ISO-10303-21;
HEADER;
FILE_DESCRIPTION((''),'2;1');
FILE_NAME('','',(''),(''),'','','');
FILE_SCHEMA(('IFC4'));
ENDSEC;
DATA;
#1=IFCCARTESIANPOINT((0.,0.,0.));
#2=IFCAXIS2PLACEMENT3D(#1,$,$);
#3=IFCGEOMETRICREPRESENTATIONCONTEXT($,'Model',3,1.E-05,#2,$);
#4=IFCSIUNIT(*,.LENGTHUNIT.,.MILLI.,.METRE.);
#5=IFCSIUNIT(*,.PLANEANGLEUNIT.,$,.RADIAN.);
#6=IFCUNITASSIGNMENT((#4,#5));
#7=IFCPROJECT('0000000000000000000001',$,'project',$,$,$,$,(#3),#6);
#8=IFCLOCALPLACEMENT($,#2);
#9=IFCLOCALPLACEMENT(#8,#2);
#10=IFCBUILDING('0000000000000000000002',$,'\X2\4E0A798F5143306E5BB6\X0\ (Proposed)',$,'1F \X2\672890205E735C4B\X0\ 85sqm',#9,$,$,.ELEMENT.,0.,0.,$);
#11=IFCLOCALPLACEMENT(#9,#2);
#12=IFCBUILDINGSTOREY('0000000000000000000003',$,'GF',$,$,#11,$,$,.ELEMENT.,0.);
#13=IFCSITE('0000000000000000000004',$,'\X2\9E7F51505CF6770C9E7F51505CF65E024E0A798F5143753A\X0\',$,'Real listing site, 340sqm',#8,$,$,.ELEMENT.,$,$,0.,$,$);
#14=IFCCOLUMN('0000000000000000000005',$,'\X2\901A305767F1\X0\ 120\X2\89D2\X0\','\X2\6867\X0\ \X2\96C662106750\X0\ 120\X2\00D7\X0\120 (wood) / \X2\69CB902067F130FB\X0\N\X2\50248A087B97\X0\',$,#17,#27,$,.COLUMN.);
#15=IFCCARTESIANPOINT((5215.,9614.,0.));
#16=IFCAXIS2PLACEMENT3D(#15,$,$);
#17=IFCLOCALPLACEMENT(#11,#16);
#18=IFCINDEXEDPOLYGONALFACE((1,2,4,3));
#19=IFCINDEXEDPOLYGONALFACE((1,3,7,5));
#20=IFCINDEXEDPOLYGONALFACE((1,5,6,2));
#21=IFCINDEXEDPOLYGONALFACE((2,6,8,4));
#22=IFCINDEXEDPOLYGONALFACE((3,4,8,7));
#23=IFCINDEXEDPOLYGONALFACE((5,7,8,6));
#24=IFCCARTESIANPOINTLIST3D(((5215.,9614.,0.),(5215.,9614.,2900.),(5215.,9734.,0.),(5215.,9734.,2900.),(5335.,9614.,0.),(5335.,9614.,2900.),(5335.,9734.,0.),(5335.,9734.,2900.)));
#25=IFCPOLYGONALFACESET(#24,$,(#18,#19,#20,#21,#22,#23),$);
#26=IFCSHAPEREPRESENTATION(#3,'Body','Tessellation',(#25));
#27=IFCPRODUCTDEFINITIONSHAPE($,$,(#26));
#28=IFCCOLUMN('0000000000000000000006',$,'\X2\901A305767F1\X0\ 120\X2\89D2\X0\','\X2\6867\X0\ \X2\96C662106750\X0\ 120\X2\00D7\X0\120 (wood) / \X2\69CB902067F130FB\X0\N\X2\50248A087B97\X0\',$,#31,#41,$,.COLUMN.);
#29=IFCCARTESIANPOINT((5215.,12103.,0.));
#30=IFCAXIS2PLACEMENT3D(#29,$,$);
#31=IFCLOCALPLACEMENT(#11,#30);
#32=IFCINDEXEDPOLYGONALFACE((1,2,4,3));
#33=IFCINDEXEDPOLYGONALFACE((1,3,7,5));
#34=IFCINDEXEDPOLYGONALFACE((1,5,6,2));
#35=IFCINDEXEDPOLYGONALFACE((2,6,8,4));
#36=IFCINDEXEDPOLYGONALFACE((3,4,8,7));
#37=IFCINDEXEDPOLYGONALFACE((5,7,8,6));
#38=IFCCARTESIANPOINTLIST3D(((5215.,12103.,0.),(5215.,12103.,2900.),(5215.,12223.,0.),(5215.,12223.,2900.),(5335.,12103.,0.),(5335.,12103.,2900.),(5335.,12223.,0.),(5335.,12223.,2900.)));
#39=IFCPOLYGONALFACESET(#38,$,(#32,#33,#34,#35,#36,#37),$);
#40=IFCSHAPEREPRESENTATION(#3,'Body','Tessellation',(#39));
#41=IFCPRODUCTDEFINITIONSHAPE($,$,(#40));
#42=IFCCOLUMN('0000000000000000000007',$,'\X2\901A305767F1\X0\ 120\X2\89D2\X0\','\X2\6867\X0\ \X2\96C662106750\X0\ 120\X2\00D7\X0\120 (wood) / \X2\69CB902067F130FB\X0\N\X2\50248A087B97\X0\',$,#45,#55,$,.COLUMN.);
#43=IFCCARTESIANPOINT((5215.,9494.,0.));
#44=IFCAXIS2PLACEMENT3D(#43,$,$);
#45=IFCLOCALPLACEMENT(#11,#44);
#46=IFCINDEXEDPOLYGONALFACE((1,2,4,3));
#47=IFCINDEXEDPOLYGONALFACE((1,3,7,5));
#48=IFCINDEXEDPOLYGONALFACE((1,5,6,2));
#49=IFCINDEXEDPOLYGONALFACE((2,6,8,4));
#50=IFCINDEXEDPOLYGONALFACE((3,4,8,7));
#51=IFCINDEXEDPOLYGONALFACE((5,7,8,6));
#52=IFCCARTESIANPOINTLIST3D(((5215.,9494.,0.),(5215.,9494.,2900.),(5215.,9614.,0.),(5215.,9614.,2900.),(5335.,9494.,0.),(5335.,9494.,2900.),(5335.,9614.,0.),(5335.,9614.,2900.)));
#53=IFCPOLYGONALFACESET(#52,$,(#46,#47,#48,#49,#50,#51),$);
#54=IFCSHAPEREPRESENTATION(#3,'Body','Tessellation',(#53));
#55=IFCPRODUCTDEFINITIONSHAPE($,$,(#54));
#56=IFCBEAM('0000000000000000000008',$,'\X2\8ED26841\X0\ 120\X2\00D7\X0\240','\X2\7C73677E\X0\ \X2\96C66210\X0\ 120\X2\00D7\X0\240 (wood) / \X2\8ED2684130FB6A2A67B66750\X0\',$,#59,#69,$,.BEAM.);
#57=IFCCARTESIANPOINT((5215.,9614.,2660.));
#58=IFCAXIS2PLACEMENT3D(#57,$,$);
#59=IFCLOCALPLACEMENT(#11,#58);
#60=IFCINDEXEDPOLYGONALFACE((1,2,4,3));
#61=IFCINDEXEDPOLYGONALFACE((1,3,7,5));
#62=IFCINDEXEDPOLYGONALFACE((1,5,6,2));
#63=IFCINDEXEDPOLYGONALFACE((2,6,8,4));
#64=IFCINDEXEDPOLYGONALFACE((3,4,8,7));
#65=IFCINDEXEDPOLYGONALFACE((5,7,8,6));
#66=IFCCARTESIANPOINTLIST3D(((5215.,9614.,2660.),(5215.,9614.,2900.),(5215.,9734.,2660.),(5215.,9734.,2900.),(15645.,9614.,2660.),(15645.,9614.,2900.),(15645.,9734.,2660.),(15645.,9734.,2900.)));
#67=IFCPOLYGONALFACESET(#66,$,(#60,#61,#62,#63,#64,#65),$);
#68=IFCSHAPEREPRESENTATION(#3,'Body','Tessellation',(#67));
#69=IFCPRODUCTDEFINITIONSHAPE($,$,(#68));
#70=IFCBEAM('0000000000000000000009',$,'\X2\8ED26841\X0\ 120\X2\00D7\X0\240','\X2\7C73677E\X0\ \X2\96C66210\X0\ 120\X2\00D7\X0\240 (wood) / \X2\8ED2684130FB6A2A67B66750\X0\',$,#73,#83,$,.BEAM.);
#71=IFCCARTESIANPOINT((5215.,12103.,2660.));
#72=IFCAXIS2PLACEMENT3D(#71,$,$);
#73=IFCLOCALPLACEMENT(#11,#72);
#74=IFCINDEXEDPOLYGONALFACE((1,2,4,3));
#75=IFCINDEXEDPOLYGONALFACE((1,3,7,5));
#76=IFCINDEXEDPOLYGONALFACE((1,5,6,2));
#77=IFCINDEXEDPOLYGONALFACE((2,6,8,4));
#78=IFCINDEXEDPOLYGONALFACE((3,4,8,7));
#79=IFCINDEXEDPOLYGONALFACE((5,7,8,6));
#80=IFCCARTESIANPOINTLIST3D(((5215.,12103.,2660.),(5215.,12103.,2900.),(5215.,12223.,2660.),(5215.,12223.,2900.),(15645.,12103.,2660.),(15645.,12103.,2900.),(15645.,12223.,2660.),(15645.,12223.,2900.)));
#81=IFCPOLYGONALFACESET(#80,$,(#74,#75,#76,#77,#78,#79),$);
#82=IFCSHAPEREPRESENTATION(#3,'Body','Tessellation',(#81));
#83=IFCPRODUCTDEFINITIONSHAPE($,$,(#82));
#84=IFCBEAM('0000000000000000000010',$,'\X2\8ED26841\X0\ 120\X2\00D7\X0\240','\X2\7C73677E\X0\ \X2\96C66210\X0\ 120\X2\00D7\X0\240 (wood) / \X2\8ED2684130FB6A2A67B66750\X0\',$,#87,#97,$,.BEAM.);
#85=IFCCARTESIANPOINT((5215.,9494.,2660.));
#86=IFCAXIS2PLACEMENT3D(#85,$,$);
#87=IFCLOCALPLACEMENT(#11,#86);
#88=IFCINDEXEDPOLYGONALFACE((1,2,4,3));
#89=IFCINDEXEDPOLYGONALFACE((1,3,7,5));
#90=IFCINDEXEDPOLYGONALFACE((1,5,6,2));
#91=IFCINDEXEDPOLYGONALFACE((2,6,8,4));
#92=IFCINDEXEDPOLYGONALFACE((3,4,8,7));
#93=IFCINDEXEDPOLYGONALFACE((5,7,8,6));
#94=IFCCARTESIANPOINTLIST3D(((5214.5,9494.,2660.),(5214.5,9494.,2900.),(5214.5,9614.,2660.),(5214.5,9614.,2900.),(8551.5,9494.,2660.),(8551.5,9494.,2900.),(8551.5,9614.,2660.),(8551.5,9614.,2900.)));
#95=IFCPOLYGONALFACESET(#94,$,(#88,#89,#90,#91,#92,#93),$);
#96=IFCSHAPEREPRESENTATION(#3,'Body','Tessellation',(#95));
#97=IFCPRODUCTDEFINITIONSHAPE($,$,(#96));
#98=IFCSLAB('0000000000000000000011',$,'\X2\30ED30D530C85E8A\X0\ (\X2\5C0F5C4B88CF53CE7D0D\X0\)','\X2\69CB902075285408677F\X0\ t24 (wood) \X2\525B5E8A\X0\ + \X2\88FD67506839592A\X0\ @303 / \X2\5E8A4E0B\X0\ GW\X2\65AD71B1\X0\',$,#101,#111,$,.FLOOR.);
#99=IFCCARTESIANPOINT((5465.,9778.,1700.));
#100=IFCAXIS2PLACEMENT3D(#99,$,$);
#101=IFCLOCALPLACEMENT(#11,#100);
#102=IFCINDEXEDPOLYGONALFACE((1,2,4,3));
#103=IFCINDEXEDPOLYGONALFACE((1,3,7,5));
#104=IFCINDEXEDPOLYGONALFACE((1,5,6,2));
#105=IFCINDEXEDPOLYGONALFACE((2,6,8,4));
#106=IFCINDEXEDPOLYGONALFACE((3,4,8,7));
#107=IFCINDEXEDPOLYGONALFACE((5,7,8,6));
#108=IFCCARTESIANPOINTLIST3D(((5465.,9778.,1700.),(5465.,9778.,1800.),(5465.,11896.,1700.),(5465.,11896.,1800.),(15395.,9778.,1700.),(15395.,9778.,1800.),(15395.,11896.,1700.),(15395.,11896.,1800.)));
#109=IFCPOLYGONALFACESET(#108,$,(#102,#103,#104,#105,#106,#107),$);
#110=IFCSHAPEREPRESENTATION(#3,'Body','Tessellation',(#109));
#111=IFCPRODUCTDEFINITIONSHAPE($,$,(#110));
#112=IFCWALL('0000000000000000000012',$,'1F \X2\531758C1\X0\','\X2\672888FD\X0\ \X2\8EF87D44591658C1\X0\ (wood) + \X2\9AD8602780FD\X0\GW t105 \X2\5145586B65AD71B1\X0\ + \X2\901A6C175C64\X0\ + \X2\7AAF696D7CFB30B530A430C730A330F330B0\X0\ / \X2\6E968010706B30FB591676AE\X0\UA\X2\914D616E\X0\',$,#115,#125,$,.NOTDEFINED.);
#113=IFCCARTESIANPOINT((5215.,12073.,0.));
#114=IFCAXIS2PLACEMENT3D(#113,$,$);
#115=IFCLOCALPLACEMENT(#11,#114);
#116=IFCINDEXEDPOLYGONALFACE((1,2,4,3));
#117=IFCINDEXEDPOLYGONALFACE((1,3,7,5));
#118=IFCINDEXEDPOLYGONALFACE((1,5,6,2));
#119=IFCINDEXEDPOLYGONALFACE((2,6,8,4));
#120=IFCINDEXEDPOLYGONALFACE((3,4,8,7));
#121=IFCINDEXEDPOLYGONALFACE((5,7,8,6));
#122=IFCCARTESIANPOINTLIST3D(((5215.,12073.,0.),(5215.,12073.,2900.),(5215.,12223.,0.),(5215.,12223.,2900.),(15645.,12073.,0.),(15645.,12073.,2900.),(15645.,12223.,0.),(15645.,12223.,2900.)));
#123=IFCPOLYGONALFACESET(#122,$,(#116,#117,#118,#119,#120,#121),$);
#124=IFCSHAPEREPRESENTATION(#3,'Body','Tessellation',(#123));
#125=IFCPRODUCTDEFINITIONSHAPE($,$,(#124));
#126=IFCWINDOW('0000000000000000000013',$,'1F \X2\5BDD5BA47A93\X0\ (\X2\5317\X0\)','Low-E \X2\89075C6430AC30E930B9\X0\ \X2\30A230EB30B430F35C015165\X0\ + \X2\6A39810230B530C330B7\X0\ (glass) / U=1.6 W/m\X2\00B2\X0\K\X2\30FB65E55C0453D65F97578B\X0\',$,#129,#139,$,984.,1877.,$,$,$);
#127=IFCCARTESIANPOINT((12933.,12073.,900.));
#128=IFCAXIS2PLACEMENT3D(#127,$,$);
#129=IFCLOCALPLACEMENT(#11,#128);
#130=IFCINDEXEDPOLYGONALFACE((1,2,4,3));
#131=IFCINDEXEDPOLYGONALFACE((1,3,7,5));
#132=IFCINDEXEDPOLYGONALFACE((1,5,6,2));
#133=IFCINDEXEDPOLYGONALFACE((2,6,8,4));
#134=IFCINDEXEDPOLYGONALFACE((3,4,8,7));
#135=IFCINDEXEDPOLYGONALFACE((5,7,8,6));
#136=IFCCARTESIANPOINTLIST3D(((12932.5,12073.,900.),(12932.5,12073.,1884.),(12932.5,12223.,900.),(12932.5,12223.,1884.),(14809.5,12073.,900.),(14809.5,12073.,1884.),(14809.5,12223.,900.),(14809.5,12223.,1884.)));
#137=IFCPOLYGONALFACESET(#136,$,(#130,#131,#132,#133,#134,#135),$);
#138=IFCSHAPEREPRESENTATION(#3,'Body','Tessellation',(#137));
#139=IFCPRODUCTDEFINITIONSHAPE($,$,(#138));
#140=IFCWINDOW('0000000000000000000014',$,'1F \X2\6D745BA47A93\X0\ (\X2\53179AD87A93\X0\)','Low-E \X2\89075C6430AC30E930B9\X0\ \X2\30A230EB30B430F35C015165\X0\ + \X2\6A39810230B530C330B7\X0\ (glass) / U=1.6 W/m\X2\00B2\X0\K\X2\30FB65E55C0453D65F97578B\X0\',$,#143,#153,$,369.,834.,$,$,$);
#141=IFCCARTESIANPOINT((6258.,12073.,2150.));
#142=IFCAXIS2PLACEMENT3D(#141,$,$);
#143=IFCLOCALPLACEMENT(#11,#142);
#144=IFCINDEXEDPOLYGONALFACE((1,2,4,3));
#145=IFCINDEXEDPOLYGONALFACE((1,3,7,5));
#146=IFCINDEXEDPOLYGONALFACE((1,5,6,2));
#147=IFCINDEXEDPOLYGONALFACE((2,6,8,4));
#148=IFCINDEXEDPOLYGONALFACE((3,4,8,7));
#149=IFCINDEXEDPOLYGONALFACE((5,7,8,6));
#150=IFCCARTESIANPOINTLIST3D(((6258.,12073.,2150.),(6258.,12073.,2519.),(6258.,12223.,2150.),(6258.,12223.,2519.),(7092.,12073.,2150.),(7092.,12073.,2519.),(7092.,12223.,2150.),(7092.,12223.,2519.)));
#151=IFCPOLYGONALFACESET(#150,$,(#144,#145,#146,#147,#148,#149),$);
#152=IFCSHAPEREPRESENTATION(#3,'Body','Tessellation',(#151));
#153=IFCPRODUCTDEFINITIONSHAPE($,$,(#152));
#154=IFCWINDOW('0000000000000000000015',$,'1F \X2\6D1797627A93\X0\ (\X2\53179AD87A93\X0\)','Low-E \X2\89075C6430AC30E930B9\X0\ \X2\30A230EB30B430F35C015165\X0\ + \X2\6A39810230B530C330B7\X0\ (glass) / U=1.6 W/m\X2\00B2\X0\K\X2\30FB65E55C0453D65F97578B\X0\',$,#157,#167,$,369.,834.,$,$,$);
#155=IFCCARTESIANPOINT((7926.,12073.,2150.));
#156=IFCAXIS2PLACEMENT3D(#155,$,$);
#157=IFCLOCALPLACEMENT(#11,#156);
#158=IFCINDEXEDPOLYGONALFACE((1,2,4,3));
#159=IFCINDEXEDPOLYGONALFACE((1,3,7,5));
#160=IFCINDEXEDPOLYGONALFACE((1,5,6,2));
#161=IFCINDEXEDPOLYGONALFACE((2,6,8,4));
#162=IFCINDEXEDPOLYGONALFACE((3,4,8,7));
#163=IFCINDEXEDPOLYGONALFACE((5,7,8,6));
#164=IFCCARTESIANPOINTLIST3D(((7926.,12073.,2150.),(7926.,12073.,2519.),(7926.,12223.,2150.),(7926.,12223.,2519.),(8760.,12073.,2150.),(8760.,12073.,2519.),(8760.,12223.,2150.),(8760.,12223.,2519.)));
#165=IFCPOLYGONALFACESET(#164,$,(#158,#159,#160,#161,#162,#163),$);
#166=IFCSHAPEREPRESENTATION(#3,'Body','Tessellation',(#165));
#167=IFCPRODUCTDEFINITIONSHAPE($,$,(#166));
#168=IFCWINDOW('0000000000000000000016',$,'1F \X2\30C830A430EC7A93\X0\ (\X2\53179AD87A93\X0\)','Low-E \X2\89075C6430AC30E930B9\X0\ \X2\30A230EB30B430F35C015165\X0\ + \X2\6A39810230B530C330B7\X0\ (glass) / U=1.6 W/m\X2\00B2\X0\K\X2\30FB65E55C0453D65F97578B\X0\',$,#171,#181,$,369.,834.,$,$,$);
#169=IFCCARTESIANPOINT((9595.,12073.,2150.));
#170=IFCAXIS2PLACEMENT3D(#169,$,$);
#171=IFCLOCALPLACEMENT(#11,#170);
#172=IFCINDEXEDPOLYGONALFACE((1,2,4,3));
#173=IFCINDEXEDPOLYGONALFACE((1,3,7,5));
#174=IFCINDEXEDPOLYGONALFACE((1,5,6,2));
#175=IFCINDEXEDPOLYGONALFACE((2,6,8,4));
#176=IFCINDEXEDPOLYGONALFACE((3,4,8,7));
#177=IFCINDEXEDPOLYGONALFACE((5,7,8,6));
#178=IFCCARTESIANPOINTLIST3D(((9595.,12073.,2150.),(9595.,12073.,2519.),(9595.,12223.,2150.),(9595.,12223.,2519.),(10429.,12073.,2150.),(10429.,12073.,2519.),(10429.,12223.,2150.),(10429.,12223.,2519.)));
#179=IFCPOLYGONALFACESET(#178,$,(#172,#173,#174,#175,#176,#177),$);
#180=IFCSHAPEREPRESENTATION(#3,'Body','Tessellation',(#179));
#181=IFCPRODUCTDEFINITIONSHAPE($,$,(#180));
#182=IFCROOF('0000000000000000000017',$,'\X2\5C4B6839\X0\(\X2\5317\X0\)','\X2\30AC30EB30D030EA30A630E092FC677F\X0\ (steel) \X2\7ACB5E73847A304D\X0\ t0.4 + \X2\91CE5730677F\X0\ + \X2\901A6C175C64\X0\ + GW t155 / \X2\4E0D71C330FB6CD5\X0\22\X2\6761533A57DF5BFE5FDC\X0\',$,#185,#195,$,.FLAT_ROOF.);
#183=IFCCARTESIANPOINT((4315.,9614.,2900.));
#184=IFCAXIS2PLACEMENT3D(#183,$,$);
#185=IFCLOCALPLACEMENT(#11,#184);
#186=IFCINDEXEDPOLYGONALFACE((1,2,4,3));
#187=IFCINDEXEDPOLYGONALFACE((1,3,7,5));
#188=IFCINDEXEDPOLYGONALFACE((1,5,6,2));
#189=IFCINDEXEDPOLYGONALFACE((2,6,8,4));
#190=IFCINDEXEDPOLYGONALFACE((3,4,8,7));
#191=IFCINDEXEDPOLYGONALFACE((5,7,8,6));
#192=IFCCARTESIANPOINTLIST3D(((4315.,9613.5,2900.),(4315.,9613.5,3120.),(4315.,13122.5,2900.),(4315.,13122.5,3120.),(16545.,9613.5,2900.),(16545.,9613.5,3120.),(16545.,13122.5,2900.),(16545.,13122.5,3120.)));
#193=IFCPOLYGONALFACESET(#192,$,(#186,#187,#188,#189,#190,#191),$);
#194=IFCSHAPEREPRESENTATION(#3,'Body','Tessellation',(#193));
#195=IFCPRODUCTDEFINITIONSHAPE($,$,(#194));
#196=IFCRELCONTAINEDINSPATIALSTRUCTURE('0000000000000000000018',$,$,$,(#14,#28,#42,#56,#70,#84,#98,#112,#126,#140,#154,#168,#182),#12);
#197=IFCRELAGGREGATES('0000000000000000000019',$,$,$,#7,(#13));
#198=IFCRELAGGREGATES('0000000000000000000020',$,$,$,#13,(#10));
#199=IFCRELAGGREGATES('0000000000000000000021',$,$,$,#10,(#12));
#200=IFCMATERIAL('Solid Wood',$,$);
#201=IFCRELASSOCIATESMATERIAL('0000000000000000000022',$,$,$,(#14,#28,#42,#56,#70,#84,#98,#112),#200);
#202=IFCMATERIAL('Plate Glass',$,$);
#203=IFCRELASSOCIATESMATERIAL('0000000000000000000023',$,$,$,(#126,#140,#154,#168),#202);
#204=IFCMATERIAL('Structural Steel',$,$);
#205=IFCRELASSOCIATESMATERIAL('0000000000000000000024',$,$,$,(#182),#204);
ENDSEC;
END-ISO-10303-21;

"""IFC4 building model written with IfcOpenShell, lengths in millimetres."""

from ifc_helpers import new_model, si_unit, frame, frame_2d, origin, place, context, project, spatial, rectangle, extrude, material, element, fill, save


model = new_model("IFC4")

# Units and contexts
model_context = context("Model", 3, precision=1e-05, world=origin())
ifc_project = project(units=[si_unit("LENGTHUNIT", "METRE", prefix="MILLI"), si_unit("PLANEANGLEUNIT", "RADIAN")], contexts=[model_context])

# Site, building, storey
site_placement = place(None, origin())
site = spatial("IfcSite", under=ifc_project, at=site_placement, Name="鹿児島県鹿児島市上福元町", ObjectType="Real listing site, 340sqm", CompositionType="ELEMENT", RefElevation=0.0)
building_placement = place(site_placement, origin())
building = spatial("IfcBuilding", under=site, at=building_placement, Name="上福元の家 (Proposed)", ObjectType="1F 木造平屋 85sqm", CompositionType="ELEMENT", ElevationOfRefHeight=0.0, ElevationOfTerrain=0.0)
storey_placement = place(building_placement, origin())
storey = spatial("IfcBuildingStorey", under=building, at=storey_placement, Name="GF", CompositionType="ELEMENT", Elevation=0.0)

# Columns
ifc_material_1 = material(Name="Solid Wood")
column_1_placement = place(storey_placement, frame((5215.0, 9614.0, 0.0)))
element("IfcColumn", 1, at=column_1_placement, inside=storey, material=ifc_material_1, Name="通し柱 120角", Description="桧 集成材 120×120 (wood) / 構造柱・N値計算", PredefinedType="COLUMN", context=model_context, shape_type="SweptSolid", body=[
    extrude(rectangle(XDim=120.0, YDim=120.0, at=frame_2d((60.0, 60.0))), frame((5215.0, 9614.0, 0.0)), (0.0, 0.0, 1.0), 2900.0),
])
column_2_placement = place(storey_placement, frame((5215.0, 12103.0, 0.0)))
element("IfcColumn", 2, at=column_2_placement, inside=storey, material=ifc_material_1, Name="通し柱 120角", Description="桧 集成材 120×120 (wood) / 構造柱・N値計算", PredefinedType="COLUMN", context=model_context, shape_type="SweptSolid", body=[
    extrude(rectangle(XDim=120.0, YDim=120.0, at=frame_2d((60.0, 60.0))), frame((5215.0, 12103.0, 0.0)), (0.0, 0.0, 1.0), 2900.0),
])
column_3_placement = place(storey_placement, frame((5215.0, 9494.0, 0.0)))
element("IfcColumn", 3, at=column_3_placement, inside=storey, material=ifc_material_1, Name="通し柱 120角", Description="桧 集成材 120×120 (wood) / 構造柱・N値計算", PredefinedType="COLUMN", context=model_context, shape_type="SweptSolid", body=[
    extrude(rectangle(XDim=120.0, YDim=120.0, at=frame_2d((60.0, 60.0))), frame((5215.0, 9494.0, 0.0)), (0.0, 0.0, 1.0), 2900.0),
])

# Beams
beam_1_placement = place(storey_placement, frame((5215.0, 9614.0, 2660.0)))
element("IfcBeam", 4, at=beam_1_placement, inside=storey, material=ifc_material_1, Name="軒桁 120×240", Description="米松 集成 120×240 (wood) / 軒桁・横架材", PredefinedType="BEAM", context=model_context, shape_type="SweptSolid", body=[
    extrude(rectangle(XDim=10430.0, YDim=120.0, at=frame_2d((5215.0, 60.0))), frame((5215.0, 9614.0, 2660.0)), (0.0, 0.0, 1.0), 240.0),
])
beam_2_placement = place(storey_placement, frame((5215.0, 12103.0, 2660.0)))
element("IfcBeam", 5, at=beam_2_placement, inside=storey, material=ifc_material_1, Name="軒桁 120×240", Description="米松 集成 120×240 (wood) / 軒桁・横架材", PredefinedType="BEAM", context=model_context, shape_type="SweptSolid", body=[
    extrude(rectangle(XDim=10430.0, YDim=120.0, at=frame_2d((5215.0, 60.0))), frame((5215.0, 12103.0, 2660.0)), (0.0, 0.0, 1.0), 240.0),
])
beam_3_placement = place(storey_placement, frame((5215.0, 9494.0, 2660.0)))
element("IfcBeam", 6, at=beam_3_placement, inside=storey, material=ifc_material_1, Name="軒桁 120×240", Description="米松 集成 120×240 (wood) / 軒桁・横架材", PredefinedType="BEAM", context=model_context, shape_type="SweptSolid", body=[
    extrude(rectangle(XDim=3337.0, YDim=120.0, at=frame_2d((1668.0, 60.0))), frame((5215.0, 9494.0, 2660.0)), (0.0, 0.0, 1.0), 240.0),
])

# Slab
slab_1_placement = place(storey_placement, frame((5465.0, 9778.0, 1700.0)))
element("IfcSlab", 7, at=slab_1_placement, inside=storey, material=ifc_material_1, Name="ロフト床 (小屋裏収納)", Description="構造用合板 t24 (wood) 剛床 + 製材根太 @303 / 床下 GW断熱", PredefinedType="FLOOR", context=model_context, shape_type="SweptSolid", body=[
    extrude(rectangle(XDim=9930.0, YDim=2118.0, at=frame_2d((4965.0, 1059.0))), frame((5465.0, 9778.0, 1700.0)), (0.0, 0.0, 1.0), 100.0),
])

# Wall, openings, windows
wall_1_placement = place(storey_placement, frame((5215.0, 12073.0, 0.0)))
wall_1 = element("IfcWall", 8, at=wall_1_placement, inside=storey, material=ifc_material_1, Name="1F 北壁", Description="木製 軸組外壁 (wood) + 高性能GW t105 充填断熱 + 通気層 + 窯業系サイディング / 準耐火・外皮UA配慮", PredefinedType="NOTDEFINED", context=model_context, shape_type="SweptSolid", body=[
    extrude(rectangle(XDim=10430.0, YDim=150.0, at=frame_2d((5215.0, 75.0))), frame((5215.0, 12073.0, 0.0)), (0.0, 0.0, 1.0), 2900.0),
])
opening_1_placement = place(storey_placement, frame((12933.0, 12073.0, 900.0)))
opening_1 = element("IfcOpeningElement", 9, at=opening_1_placement, cuts=wall_1, PredefinedType="NOTDEFINED", context=model_context, shape_type="SweptSolid", body=[
    extrude(rectangle(XDim=1877.0, YDim=150.0, at=frame_2d((938.0, 75.0))), frame((12933.0, 12073.0, 900.0)), (0.0, 0.0, 1.0), 984.0),
])
opening_2_placement = place(storey_placement, frame((6258.0, 12073.0, 2150.0)))
opening_2 = element("IfcOpeningElement", 10, at=opening_2_placement, cuts=wall_1, PredefinedType="NOTDEFINED", context=model_context, shape_type="SweptSolid", body=[
    extrude(rectangle(XDim=834.0, YDim=150.0, at=frame_2d((417.0, 75.0))), frame((6258.0, 12073.0, 2150.0)), (0.0, 0.0, 1.0), 369.0),
])
opening_3_placement = place(storey_placement, frame((7926.0, 12073.0, 2150.0)))
opening_3 = element("IfcOpeningElement", 11, at=opening_3_placement, cuts=wall_1, PredefinedType="NOTDEFINED", context=model_context, shape_type="SweptSolid", body=[
    extrude(rectangle(XDim=834.0, YDim=150.0, at=frame_2d((417.0, 75.0))), frame((7926.0, 12073.0, 2150.0)), (0.0, 0.0, 1.0), 369.0),
])
opening_4_placement = place(storey_placement, frame((9595.0, 12073.0, 2150.0)))
opening_4 = element("IfcOpeningElement", 12, at=opening_4_placement, cuts=wall_1, PredefinedType="NOTDEFINED", context=model_context, shape_type="SweptSolid", body=[
    extrude(rectangle(XDim=834.0, YDim=150.0, at=frame_2d((417.0, 75.0))), frame((9595.0, 12073.0, 2150.0)), (0.0, 0.0, 1.0), 369.0),
])
ifc_material_2 = material(Name="Plate Glass")
window_1_placement = place(storey_placement, frame((12933.0, 12073.0, 900.0)))
window_1 = element("IfcWindow", 13, at=window_1_placement, inside=storey, material=ifc_material_2, Name="1F 寝室窓 (北)", Description="Low-E 複層ガラス アルゴン封入 + 樹脂サッシ (glass) / U=1.6 W/m²K・日射取得型", OverallHeight=984.0, OverallWidth=1877.0, context=model_context, shape_type="SweptSolid", body=[
    extrude(rectangle(XDim=1877.0, YDim=150.0, at=frame_2d((938.0, 75.0))), frame((12933.0, 12073.0, 900.0)), (0.0, 0.0, 1.0), 984.0),
])
fill(opening_1, window_1)
window_2_placement = place(storey_placement, frame((6258.0, 12073.0, 2150.0)))
window_2 = element("IfcWindow", 14, at=window_2_placement, inside=storey, material=ifc_material_2, Name="1F 浴室窓 (北高窓)", Description="Low-E 複層ガラス アルゴン封入 + 樹脂サッシ (glass) / U=1.6 W/m²K・日射取得型", OverallHeight=369.0, OverallWidth=834.0, context=model_context, shape_type="SweptSolid", body=[
    extrude(rectangle(XDim=834.0, YDim=150.0, at=frame_2d((417.0, 75.0))), frame((6258.0, 12073.0, 2150.0)), (0.0, 0.0, 1.0), 369.0),
])
fill(opening_2, window_2)
window_3_placement = place(storey_placement, frame((7926.0, 12073.0, 2150.0)))
window_3 = element("IfcWindow", 15, at=window_3_placement, inside=storey, material=ifc_material_2, Name="1F 洗面窓 (北高窓)", Description="Low-E 複層ガラス アルゴン封入 + 樹脂サッシ (glass) / U=1.6 W/m²K・日射取得型", OverallHeight=369.0, OverallWidth=834.0, context=model_context, shape_type="SweptSolid", body=[
    extrude(rectangle(XDim=834.0, YDim=150.0, at=frame_2d((417.0, 75.0))), frame((7926.0, 12073.0, 2150.0)), (0.0, 0.0, 1.0), 369.0),
])
fill(opening_3, window_3)
window_4_placement = place(storey_placement, frame((9595.0, 12073.0, 2150.0)))
window_4 = element("IfcWindow", 16, at=window_4_placement, inside=storey, material=ifc_material_2, Name="1F トイレ窓 (北高窓)", Description="Low-E 複層ガラス アルゴン封入 + 樹脂サッシ (glass) / U=1.6 W/m²K・日射取得型", OverallHeight=369.0, OverallWidth=834.0, context=model_context, shape_type="SweptSolid", body=[
    extrude(rectangle(XDim=834.0, YDim=150.0, at=frame_2d((417.0, 75.0))), frame((9595.0, 12073.0, 2150.0)), (0.0, 0.0, 1.0), 369.0),
])
fill(opening_4, window_4)

# Roof
ifc_material_3 = material(Name="Structural Steel")
roof_placement = place(storey_placement, frame((4315.0, 9614.0, 2900.0)))
element("IfcRoof", 17, at=roof_placement, inside=storey, material=ifc_material_3, Name="屋根(北)", Description="ガルバリウム鋼板 (steel) 立平葺き t0.4 + 野地板 + 通気層 + GW t155 / 不燃・法22条区域対応", PredefinedType="FLAT_ROOF", context=model_context, shape_type="SweptSolid", body=[
    extrude(rectangle(XDim=12230.0, YDim=3509.0, at=frame_2d((6115.0, 1754.0))), frame((4315.0, 9614.0, 2900.0)), (0.0, 0.0, 1.0), 220.0),
])

save(model, "model.ifc")
